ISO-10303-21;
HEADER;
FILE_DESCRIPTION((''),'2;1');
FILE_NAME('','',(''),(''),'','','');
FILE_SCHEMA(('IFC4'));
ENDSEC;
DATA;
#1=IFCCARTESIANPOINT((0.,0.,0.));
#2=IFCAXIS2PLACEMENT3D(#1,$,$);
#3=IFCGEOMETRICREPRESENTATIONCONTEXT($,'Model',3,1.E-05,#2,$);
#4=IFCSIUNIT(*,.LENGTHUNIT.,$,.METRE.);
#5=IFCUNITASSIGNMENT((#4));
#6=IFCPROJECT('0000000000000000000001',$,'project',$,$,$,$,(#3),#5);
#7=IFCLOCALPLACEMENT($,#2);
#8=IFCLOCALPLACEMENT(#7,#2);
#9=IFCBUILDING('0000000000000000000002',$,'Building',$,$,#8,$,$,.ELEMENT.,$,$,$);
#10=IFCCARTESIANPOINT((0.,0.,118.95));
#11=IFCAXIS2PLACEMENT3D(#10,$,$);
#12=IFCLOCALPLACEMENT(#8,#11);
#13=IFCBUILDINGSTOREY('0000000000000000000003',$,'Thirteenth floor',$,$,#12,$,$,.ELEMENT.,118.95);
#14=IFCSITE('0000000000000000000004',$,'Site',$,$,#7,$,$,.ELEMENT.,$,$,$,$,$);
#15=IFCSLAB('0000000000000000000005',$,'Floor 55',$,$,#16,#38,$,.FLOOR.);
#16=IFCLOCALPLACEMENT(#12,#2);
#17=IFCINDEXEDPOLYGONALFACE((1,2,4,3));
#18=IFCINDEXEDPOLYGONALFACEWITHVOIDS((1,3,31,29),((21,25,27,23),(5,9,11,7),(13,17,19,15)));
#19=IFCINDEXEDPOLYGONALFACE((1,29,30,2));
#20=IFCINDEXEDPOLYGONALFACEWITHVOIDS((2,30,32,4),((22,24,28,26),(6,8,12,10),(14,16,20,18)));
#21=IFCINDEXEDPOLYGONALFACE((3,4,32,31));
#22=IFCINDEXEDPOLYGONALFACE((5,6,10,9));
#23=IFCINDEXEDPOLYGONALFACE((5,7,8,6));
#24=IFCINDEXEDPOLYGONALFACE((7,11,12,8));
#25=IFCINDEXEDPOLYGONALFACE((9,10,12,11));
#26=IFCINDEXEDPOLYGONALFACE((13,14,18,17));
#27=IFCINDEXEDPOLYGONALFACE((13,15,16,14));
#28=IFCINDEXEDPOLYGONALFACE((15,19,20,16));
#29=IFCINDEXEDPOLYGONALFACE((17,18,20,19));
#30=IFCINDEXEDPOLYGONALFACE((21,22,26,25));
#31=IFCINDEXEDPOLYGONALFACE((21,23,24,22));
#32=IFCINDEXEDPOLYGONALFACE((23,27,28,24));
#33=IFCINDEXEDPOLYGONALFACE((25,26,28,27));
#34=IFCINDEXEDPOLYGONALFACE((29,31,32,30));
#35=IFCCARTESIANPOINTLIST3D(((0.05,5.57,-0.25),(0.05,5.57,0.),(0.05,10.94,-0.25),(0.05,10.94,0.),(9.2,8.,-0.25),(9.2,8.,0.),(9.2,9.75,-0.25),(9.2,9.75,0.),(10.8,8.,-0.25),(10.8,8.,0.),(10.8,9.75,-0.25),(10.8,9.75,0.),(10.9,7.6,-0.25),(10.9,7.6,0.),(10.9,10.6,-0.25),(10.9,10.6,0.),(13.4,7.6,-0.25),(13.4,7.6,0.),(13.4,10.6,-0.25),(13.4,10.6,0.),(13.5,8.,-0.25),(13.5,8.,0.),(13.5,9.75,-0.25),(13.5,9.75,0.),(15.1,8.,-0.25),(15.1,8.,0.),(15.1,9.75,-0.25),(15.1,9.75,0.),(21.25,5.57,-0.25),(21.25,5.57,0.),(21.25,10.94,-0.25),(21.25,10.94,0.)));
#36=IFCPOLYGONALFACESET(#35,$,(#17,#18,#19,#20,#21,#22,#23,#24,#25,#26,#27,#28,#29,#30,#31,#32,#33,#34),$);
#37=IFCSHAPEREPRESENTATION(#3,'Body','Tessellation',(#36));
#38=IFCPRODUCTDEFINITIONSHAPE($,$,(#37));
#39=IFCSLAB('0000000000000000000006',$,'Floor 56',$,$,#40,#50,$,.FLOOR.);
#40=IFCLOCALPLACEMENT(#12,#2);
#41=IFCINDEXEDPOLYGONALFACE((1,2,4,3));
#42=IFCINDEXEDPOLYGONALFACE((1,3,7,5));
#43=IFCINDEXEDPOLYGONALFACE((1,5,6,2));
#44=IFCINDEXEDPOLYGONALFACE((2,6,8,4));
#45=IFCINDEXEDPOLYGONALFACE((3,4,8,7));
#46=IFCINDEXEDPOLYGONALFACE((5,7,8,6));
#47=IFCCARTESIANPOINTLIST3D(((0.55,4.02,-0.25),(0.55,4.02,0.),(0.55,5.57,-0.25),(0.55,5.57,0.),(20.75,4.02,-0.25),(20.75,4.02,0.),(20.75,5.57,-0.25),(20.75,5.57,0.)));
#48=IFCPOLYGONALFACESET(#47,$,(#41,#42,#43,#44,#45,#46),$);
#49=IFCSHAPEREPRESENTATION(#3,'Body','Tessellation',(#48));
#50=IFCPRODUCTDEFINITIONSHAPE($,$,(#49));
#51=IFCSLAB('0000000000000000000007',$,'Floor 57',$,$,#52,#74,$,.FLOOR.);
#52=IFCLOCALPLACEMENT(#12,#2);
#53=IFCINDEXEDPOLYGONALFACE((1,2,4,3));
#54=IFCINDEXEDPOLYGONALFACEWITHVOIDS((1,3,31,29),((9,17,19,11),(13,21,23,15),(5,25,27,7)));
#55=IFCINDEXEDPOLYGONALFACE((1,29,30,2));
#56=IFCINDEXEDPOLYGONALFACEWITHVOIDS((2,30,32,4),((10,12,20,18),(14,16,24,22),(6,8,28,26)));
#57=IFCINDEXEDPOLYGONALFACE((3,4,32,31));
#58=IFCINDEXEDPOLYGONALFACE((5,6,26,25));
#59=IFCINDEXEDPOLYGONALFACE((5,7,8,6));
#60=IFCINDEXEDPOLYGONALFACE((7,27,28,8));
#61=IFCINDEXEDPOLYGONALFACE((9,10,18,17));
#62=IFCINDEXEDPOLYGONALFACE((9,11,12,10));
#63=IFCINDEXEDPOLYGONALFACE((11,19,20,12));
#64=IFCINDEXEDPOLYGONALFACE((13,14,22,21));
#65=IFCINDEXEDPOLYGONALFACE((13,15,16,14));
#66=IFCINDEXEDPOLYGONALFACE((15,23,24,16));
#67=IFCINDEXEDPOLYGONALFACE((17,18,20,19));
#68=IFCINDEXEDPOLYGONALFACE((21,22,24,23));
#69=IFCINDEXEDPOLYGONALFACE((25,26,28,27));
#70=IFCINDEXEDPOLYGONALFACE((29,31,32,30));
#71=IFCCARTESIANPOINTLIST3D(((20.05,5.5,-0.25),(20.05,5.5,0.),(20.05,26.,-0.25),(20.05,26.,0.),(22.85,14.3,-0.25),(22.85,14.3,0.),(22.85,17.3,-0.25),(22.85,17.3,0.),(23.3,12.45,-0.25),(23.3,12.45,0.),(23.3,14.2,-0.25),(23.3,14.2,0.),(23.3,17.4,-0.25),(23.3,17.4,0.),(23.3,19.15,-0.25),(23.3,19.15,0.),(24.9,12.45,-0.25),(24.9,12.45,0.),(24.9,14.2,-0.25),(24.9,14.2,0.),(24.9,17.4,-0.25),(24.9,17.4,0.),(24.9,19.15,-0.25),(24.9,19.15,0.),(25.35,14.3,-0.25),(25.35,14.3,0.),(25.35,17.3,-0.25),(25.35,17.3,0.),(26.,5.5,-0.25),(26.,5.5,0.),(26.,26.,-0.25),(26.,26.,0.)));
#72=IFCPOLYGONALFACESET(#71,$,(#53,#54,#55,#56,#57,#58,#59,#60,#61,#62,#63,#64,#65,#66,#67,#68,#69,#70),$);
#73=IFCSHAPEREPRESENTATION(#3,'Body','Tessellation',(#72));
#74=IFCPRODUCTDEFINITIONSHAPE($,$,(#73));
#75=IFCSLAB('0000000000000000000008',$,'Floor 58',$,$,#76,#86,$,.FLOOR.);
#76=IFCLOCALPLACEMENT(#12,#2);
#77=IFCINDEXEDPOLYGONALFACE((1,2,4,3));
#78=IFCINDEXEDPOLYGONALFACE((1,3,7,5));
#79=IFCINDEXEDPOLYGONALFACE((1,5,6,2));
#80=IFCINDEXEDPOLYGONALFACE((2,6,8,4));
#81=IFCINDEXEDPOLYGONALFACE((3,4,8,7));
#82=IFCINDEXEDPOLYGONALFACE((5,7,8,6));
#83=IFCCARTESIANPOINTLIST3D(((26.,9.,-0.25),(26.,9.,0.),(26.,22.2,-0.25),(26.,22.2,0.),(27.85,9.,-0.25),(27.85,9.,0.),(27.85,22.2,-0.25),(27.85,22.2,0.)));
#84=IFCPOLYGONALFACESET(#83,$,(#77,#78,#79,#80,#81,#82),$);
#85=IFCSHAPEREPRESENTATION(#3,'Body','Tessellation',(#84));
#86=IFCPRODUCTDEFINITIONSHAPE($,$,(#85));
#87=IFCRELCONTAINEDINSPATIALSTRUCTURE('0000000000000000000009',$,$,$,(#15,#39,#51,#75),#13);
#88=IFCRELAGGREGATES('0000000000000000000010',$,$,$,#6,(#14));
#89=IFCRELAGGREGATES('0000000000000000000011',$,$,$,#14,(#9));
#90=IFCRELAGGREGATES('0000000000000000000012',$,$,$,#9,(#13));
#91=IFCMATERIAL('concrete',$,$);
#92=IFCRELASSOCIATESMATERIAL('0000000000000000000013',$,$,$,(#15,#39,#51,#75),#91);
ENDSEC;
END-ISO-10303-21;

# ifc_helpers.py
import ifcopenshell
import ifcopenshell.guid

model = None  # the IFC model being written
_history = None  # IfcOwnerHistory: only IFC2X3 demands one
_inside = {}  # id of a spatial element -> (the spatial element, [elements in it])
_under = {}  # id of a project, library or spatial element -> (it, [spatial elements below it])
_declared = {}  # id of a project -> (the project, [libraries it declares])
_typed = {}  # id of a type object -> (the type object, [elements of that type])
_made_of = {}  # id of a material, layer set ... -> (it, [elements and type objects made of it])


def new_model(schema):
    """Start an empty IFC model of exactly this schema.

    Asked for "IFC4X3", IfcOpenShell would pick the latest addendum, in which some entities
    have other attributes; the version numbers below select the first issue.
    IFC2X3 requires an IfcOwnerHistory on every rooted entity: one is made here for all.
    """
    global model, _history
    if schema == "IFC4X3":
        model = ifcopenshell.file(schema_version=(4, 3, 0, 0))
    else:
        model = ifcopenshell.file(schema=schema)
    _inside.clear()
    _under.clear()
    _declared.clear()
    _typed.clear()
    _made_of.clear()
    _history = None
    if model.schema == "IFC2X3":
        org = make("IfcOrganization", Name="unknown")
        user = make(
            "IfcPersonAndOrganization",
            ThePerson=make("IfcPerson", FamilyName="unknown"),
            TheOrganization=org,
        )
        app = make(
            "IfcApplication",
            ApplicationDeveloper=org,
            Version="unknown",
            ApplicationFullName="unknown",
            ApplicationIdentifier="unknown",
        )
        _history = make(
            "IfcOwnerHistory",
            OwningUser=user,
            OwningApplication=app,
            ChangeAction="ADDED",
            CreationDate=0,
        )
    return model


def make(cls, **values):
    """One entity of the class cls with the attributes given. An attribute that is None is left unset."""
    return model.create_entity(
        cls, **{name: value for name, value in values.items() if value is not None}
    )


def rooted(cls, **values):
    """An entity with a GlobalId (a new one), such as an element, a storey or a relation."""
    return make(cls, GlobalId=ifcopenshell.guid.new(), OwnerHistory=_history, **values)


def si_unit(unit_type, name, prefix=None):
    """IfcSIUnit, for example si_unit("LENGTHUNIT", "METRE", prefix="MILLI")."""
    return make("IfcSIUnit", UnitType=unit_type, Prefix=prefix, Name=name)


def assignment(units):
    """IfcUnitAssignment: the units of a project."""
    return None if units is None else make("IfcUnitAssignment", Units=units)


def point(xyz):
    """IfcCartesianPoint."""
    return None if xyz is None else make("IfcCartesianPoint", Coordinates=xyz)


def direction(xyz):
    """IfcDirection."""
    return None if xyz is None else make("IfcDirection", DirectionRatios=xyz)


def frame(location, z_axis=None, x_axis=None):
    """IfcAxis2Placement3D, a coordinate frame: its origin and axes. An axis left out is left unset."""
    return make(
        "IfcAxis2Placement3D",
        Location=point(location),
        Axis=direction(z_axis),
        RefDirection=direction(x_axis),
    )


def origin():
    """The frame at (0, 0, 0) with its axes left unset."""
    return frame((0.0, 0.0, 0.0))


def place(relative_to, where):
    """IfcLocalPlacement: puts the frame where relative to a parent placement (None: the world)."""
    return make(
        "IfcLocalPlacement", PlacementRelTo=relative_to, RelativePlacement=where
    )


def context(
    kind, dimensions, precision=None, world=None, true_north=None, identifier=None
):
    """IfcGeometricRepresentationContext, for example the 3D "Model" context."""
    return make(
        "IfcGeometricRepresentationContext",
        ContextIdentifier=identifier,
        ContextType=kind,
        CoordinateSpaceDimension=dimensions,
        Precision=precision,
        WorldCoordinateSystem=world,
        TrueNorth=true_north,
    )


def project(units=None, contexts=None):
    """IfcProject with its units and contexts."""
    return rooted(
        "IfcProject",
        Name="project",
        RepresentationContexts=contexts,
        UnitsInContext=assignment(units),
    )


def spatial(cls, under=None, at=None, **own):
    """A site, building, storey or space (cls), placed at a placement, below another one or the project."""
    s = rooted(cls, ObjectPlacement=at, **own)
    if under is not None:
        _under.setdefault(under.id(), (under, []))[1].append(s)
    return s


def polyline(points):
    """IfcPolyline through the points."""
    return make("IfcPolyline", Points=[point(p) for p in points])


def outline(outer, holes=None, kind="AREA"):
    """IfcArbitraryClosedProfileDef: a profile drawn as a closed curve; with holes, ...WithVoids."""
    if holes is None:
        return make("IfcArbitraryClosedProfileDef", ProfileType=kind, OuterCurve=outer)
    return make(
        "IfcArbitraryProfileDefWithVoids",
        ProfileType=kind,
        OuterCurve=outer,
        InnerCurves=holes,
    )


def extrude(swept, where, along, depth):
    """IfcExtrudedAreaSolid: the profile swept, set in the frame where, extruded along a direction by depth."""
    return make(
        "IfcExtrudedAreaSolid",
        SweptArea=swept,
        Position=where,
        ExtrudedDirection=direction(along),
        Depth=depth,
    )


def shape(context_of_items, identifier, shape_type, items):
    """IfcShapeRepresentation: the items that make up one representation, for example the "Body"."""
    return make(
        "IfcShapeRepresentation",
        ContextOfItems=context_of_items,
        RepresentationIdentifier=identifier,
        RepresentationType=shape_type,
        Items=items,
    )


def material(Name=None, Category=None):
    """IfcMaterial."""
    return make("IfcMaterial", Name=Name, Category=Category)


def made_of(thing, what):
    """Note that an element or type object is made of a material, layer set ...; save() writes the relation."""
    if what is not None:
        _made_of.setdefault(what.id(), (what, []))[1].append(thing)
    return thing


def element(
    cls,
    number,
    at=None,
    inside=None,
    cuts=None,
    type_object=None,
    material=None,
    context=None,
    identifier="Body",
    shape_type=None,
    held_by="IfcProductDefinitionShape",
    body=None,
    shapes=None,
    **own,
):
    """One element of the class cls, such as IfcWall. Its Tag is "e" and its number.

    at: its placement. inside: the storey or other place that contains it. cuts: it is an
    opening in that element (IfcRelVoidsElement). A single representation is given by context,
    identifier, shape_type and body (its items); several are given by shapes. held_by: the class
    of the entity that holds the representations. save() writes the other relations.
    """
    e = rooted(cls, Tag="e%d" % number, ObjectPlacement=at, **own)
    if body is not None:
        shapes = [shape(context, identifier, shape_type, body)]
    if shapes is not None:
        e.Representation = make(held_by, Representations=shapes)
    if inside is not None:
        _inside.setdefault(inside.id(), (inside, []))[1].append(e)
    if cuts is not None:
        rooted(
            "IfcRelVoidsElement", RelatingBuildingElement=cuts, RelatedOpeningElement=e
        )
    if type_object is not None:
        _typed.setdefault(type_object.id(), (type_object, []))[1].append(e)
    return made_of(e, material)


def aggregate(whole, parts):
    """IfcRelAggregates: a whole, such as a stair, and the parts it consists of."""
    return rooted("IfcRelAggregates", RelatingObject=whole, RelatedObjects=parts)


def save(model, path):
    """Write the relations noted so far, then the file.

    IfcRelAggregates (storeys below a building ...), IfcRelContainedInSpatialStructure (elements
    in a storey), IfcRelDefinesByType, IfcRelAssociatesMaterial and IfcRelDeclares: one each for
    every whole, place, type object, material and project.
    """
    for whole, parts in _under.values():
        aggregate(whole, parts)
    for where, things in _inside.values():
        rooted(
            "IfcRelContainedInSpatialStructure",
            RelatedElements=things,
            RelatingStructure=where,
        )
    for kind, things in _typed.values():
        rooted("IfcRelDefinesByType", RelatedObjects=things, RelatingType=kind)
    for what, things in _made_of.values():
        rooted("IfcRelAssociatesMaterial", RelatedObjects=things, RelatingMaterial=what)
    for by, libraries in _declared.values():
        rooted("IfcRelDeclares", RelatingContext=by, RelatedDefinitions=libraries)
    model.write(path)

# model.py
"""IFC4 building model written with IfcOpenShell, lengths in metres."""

from ifc_helpers import new_model, si_unit, frame, origin, place, context, project, spatial, polyline, outline, extrude, material, element, save


model = new_model("IFC4")

# Units and contexts
model_context = context("Model", 3, precision=1e-05, world=origin())
ifc_project = project(units=[si_unit("LENGTHUNIT", "METRE")], contexts=[model_context])

# Site, building, storey
site_placement = place(None, origin())
site = spatial("IfcSite", under=ifc_project, at=site_placement, Name="Site", CompositionType="ELEMENT")
building_placement = place(site_placement, origin())
building = spatial("IfcBuilding", under=site, at=building_placement, Name="Building", CompositionType="ELEMENT")
storey_placement = place(building_placement, frame((0.0, 0.0, 118.95)))
storey = spatial("IfcBuildingStorey", under=building, at=storey_placement, Name="Thirteenth floor", CompositionType="ELEMENT", Elevation=118.95)

# Slabs
ifc_material = material(Name="concrete")
slab_1_placement = place(storey_placement, frame((0.0, 0.0, -0.25), z_axis=(0.0, 0.0, 1.0), x_axis=(1.0, 0.0, 0.0)))
element("IfcSlab", 1, at=slab_1_placement, inside=storey, material=ifc_material, Name="Floor 55", PredefinedType="FLOOR", context=model_context, shape_type="SweptSolid", body=[
    extrude(outline(polyline([(0.05, 5.57), (21.25, 5.57), (21.25, 10.94), (0.05, 10.94), (0.05, 5.57)]), holes=[polyline([(10.9, 7.6), (13.4, 7.6), (13.4, 10.6), (10.9, 10.6), (10.9, 7.6)]), polyline([(9.2, 8.0), (10.8, 8.0), (10.8, 9.75), (9.2, 9.75), (9.2, 8.0)]), polyline([(13.5, 8.0), (15.1, 8.0), (15.1, 9.75), (13.5, 9.75), (13.5, 8.0)])]), origin(), (0.0, 0.0, 1.0), 0.25),
])
slab_2_placement = place(storey_placement, frame((0.0, 0.0, -0.25), z_axis=(0.0, 0.0, 1.0), x_axis=(1.0, 0.0, 0.0)))
element("IfcSlab", 2, at=slab_2_placement, inside=storey, material=ifc_material, Name="Floor 56", PredefinedType="FLOOR", context=model_context, shape_type="SweptSolid", body=[
    extrude(outline(polyline([(0.55, 4.02), (20.75, 4.02), (20.75, 5.57), (0.55, 5.57), (0.55, 4.02)])), origin(), (0.0, 0.0, 1.0), 0.25),
])
slab_3_placement = place(storey_placement, frame((0.0, 0.0, -0.25), z_axis=(0.0, 0.0, 1.0), x_axis=(1.0, 0.0, 0.0)))
element("IfcSlab", 3, at=slab_3_placement, inside=storey, material=ifc_material, Name="Floor 57", PredefinedType="FLOOR", context=model_context, shape_type="SweptSolid", body=[
    extrude(outline(polyline([(20.05, 5.5), (26.0, 5.5), (26.0, 26.0), (20.05, 26.0), (20.05, 5.5)]), holes=[polyline([(22.85, 14.3), (25.35, 14.3), (25.35, 17.3), (22.85, 17.3), (22.85, 14.3)]), polyline([(23.3, 17.4), (24.9, 17.4), (24.9, 19.15), (23.3, 19.15), (23.3, 17.4)]), polyline([(23.3, 12.45), (24.9, 12.45), (24.9, 14.2), (23.3, 14.2), (23.3, 12.45)])]), origin(), (0.0, 0.0, 1.0), 0.25),
])
slab_4_placement = place(storey_placement, frame((0.0, 0.0, -0.25), z_axis=(0.0, 0.0, 1.0), x_axis=(1.0, 0.0, 0.0)))
element("IfcSlab", 4, at=slab_4_placement, inside=storey, material=ifc_material, Name="Floor 58", PredefinedType="FLOOR", context=model_context, shape_type="SweptSolid", body=[
    extrude(outline(polyline([(26.0, 9.0), (27.85, 9.0), (27.85, 22.2), (26.0, 22.2), (26.0, 9.0)])), origin(), (0.0, 0.0, 1.0), 0.25),
])

save(model, "model.ifc")
